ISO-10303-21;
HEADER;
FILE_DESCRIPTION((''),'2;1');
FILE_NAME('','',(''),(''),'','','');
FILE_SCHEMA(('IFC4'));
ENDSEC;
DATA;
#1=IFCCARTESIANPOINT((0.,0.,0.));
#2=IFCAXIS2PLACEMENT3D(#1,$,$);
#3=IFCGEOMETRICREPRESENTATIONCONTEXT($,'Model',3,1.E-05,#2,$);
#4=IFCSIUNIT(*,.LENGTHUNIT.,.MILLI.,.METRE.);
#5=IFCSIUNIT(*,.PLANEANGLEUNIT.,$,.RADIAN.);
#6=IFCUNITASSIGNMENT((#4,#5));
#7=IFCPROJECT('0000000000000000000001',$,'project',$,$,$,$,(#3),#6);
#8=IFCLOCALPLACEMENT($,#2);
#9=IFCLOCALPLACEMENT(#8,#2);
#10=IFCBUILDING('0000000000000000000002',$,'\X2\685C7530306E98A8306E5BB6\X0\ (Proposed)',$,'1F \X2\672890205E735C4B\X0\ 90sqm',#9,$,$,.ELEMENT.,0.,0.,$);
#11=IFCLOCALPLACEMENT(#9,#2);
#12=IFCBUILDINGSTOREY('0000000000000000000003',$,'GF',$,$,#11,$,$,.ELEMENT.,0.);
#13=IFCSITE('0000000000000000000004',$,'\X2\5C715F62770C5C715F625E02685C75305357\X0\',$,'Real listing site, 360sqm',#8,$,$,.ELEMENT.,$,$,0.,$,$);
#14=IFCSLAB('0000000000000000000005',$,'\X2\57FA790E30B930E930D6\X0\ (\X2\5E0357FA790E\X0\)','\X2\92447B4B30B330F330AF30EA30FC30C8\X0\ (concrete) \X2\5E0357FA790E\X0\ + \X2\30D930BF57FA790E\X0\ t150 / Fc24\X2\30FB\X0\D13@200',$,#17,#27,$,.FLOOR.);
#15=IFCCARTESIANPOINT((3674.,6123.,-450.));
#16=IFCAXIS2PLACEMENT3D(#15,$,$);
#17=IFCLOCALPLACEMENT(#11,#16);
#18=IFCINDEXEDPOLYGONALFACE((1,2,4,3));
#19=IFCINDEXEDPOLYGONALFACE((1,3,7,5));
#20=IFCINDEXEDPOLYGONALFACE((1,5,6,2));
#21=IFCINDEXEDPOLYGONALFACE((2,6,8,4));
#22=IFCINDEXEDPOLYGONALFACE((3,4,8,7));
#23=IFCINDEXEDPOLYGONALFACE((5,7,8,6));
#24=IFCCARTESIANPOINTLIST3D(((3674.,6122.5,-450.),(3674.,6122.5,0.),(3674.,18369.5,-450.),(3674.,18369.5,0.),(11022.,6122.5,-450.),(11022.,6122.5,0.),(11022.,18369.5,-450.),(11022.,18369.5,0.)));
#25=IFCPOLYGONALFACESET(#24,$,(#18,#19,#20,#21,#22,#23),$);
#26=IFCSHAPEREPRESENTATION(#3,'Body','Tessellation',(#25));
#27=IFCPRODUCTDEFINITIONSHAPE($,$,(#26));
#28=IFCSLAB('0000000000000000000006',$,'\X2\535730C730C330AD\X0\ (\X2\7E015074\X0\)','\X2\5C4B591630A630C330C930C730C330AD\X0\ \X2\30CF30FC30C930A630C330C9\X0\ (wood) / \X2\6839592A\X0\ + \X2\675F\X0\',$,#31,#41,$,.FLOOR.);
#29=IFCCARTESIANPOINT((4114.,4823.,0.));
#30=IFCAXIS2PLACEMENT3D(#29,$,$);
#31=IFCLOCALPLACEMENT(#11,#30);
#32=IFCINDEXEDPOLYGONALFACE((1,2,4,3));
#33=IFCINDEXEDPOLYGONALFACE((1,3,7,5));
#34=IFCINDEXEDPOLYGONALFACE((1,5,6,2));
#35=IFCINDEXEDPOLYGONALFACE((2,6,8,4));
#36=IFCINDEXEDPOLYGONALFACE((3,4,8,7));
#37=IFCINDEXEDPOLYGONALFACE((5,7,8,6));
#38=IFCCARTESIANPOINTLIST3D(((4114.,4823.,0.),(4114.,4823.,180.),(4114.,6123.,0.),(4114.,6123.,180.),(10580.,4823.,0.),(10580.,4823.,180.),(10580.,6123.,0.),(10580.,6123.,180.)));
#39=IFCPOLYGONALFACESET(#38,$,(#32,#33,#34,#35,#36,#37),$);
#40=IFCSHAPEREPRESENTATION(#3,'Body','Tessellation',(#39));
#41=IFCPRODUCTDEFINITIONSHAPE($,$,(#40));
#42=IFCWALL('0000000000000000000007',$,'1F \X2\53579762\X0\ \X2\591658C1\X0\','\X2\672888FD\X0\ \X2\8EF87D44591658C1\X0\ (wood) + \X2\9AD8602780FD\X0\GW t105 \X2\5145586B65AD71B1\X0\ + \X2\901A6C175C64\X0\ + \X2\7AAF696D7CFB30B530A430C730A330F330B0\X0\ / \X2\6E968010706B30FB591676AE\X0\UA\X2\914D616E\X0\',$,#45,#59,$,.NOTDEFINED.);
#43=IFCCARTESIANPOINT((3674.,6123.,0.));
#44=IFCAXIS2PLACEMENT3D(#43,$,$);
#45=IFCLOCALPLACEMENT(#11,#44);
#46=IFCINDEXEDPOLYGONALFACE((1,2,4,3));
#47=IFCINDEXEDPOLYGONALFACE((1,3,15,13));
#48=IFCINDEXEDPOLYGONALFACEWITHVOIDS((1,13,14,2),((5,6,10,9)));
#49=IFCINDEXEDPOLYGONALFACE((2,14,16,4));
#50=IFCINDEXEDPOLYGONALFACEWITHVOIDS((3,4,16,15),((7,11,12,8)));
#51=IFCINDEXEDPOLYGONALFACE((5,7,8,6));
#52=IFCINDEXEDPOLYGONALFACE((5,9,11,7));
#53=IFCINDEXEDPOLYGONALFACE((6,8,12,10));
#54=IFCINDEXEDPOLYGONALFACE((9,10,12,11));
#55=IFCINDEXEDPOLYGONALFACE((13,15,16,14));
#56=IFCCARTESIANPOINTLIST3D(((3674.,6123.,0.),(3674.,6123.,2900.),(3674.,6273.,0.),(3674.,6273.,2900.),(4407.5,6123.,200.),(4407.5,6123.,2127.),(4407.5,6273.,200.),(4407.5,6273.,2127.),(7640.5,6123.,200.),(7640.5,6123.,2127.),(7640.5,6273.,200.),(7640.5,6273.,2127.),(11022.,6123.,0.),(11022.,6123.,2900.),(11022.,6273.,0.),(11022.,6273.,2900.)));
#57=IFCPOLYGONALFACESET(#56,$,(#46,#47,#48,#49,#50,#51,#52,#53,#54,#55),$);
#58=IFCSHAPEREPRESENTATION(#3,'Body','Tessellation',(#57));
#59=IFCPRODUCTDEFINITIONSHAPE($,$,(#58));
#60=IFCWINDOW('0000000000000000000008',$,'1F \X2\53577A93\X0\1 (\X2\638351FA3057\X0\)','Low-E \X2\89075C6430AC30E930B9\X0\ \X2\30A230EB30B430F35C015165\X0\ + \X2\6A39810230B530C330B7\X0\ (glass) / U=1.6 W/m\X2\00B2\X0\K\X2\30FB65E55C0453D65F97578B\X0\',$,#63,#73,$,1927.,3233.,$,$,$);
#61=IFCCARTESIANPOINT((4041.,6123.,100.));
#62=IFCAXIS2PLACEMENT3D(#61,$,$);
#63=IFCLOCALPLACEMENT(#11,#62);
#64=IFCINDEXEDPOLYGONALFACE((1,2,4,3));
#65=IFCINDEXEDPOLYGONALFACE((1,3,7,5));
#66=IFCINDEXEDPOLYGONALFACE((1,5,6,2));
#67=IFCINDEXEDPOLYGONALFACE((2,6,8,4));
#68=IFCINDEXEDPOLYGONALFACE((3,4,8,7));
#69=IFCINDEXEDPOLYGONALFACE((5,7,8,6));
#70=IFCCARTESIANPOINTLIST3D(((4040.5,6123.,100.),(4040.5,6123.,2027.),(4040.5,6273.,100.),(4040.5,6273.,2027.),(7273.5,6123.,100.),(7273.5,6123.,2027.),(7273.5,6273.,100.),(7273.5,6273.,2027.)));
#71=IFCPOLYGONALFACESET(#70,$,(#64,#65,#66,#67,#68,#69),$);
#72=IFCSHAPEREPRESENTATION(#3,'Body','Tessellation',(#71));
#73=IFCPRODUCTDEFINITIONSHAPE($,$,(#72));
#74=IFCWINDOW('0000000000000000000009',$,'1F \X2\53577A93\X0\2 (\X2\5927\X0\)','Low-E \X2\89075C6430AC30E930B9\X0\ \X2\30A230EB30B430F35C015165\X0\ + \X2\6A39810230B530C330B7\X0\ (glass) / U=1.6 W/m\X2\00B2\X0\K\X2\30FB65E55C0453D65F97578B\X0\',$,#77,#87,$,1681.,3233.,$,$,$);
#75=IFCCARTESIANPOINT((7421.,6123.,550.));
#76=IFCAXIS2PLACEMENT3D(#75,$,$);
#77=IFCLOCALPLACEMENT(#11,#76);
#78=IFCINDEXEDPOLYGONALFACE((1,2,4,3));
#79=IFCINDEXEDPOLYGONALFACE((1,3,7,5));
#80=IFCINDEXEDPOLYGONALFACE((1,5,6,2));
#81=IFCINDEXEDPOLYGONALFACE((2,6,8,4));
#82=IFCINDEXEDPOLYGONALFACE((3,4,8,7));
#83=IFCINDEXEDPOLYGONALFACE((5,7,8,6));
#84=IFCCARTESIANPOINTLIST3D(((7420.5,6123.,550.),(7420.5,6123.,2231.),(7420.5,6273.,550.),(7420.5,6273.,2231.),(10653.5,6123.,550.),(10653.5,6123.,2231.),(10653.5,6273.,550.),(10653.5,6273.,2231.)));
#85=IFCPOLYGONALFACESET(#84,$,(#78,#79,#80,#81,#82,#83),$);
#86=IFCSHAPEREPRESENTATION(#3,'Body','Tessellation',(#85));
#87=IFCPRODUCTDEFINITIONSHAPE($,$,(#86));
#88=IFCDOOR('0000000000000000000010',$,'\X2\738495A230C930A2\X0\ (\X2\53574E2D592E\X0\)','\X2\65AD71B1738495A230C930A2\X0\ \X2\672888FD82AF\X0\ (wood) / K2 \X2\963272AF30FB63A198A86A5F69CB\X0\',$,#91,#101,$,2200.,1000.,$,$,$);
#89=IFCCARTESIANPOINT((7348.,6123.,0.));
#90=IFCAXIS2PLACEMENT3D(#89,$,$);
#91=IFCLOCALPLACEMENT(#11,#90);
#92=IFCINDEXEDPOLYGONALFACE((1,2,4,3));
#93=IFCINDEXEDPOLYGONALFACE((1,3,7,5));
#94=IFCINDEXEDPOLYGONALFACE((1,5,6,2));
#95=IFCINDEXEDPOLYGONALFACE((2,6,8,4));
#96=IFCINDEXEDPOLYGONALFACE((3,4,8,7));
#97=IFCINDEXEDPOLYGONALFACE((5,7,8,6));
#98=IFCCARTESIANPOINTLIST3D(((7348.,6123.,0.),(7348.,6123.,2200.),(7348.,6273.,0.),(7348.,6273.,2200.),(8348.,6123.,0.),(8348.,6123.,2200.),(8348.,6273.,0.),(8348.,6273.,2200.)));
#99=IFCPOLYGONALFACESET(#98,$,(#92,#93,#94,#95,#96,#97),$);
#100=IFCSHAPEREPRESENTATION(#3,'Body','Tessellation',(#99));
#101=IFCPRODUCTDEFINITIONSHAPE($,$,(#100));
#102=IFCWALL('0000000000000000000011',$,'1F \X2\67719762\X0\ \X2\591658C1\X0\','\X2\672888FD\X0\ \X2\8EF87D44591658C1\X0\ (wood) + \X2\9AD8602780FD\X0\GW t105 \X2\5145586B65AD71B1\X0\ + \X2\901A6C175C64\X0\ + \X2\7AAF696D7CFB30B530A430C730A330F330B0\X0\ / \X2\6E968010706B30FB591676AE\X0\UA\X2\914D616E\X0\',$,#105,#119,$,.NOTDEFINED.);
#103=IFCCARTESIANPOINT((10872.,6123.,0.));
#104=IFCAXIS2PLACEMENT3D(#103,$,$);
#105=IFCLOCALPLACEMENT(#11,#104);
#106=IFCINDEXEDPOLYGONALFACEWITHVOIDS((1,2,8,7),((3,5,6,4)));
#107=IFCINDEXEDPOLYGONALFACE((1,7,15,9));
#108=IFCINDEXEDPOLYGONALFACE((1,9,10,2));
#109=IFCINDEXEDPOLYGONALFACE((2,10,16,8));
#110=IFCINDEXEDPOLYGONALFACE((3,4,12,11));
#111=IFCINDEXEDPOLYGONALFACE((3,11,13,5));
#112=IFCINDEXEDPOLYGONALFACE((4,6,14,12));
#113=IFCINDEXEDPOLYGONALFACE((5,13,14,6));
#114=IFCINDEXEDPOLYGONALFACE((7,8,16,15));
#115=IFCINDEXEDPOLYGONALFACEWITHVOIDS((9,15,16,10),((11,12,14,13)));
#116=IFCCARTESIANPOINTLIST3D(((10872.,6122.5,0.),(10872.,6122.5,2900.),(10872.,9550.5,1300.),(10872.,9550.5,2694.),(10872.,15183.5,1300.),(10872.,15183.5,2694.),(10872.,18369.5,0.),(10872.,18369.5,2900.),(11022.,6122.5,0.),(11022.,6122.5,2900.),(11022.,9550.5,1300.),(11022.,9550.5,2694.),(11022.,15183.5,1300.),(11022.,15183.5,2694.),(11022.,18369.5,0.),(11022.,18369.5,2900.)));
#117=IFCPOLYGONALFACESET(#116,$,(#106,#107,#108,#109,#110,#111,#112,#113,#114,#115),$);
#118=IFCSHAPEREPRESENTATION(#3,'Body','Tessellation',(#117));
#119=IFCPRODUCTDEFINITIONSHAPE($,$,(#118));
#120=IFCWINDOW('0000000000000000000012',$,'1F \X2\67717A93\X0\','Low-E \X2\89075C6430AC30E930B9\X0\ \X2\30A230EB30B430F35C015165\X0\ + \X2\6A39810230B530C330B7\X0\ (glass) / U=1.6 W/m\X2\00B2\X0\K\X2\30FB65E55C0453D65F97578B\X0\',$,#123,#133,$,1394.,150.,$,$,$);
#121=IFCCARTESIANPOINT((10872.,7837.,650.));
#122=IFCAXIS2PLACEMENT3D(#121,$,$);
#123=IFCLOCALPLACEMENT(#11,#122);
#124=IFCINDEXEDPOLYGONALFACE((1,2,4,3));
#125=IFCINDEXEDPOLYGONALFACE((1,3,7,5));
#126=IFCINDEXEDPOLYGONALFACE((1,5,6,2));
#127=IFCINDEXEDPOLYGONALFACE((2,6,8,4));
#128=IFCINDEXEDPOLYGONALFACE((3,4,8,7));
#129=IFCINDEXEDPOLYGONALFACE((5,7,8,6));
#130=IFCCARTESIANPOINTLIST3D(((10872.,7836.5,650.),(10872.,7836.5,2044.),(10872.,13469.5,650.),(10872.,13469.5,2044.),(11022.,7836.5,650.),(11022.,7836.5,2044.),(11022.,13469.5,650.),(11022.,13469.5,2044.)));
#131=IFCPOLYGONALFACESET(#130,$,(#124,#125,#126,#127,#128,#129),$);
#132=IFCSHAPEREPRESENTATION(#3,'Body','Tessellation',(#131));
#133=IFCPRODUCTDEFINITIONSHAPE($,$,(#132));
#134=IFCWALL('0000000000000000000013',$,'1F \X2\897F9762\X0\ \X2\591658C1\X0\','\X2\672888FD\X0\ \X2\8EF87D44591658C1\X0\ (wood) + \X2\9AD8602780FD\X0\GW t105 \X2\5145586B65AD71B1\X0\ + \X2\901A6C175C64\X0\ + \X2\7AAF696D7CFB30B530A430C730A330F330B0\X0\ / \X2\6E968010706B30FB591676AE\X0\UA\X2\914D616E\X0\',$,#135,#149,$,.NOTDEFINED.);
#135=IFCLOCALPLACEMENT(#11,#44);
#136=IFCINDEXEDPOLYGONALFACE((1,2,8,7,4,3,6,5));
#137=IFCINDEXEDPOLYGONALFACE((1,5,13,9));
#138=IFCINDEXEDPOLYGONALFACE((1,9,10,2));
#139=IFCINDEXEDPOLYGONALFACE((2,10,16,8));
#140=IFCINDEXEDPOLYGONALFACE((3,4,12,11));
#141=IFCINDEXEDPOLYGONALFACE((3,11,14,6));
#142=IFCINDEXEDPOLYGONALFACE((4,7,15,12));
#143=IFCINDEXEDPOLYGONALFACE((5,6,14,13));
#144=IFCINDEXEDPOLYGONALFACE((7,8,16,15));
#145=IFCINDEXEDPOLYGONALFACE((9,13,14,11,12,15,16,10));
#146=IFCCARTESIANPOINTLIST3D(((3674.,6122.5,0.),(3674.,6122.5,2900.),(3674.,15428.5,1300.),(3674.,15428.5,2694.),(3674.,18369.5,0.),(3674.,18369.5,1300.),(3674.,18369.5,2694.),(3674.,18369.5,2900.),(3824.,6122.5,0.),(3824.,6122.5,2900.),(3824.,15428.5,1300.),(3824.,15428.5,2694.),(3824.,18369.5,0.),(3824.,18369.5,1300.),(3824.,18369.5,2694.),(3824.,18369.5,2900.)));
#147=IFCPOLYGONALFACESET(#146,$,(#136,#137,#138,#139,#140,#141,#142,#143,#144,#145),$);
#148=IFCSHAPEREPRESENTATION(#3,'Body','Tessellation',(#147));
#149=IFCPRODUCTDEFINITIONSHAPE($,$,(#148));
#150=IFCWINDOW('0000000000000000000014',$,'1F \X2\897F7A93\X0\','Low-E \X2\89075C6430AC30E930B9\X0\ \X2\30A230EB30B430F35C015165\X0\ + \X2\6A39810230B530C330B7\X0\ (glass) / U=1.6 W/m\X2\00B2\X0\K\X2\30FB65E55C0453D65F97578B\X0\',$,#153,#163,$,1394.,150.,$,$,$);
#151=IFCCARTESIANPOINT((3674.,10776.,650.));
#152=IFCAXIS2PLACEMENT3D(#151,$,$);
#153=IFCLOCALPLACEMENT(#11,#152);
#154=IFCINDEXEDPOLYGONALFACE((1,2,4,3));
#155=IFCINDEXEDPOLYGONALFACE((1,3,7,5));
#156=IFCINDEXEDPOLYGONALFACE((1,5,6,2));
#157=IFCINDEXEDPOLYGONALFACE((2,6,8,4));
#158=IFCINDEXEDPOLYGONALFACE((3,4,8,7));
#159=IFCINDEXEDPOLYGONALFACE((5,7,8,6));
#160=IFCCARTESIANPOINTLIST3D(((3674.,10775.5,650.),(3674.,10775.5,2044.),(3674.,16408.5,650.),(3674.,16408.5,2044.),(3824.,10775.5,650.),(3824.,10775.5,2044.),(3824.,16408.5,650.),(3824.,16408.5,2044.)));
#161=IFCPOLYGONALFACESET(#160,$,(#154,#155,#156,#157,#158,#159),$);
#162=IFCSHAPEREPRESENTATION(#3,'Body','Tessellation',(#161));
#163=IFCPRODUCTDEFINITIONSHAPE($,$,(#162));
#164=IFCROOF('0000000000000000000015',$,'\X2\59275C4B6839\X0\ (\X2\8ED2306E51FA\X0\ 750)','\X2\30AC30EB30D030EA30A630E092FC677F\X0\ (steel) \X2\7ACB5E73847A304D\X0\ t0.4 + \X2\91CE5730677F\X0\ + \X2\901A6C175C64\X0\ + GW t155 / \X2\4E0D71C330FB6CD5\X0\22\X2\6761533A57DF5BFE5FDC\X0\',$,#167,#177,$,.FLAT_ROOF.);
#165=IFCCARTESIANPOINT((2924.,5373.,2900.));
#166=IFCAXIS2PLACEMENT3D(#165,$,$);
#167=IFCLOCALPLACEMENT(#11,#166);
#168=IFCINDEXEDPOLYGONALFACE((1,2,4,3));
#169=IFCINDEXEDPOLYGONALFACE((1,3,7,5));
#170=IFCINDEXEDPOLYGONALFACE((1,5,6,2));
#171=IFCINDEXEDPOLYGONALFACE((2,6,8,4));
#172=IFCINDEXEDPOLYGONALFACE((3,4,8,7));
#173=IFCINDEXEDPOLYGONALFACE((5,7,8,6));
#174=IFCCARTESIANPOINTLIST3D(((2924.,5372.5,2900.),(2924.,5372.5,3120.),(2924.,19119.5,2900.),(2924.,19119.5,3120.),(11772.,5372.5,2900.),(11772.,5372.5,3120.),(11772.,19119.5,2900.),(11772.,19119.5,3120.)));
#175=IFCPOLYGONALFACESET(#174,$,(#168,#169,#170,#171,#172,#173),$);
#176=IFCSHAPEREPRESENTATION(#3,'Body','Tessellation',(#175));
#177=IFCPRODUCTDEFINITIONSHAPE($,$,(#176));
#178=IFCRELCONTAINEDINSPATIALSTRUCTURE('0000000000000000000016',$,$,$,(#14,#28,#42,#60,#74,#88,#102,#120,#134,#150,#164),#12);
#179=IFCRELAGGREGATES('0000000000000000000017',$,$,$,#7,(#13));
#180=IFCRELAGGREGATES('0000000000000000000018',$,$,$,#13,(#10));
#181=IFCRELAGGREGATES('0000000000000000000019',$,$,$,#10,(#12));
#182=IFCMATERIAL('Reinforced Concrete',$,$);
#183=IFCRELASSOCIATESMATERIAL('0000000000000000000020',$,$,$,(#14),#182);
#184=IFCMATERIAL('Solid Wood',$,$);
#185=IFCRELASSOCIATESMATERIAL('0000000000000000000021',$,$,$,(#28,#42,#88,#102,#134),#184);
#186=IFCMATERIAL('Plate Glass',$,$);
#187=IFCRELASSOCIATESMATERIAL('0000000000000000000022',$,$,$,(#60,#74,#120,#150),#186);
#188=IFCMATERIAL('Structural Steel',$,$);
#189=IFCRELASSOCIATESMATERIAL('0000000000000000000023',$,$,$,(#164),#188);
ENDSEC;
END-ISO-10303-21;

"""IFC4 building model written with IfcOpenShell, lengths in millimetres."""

from ifc_helpers import new_model, si_unit, frame, frame_2d, origin, place, context, project, spatial, rectangle, extrude, material, element, fill, save


model = new_model("IFC4")

# Units and contexts
model_context = context("Model", 3, precision=1e-05, world=origin())
ifc_project = project(units=[si_unit("LENGTHUNIT", "METRE", prefix="MILLI"), si_unit("PLANEANGLEUNIT", "RADIAN")], contexts=[model_context])

# Site, building, storey
site_placement = place(None, origin())
site = spatial("IfcSite", under=ifc_project, at=site_placement, Name="山形県山形市桜田南", ObjectType="Real listing site, 360sqm", CompositionType="ELEMENT", RefElevation=0.0)
building_placement = place(site_placement, origin())
building = spatial("IfcBuilding", under=site, at=building_placement, Name="桜田の風の家 (Proposed)", ObjectType="1F 木造平屋 90sqm", CompositionType="ELEMENT", ElevationOfRefHeight=0.0, ElevationOfTerrain=0.0)
storey_placement = place(building_placement, origin())
storey = spatial("IfcBuildingStorey", under=building, at=storey_placement, Name="GF", CompositionType="ELEMENT", Elevation=0.0)

# Slabs
ifc_material_1 = material(Name="Reinforced Concrete")
slab_1_placement = place(storey_placement, frame((3674.0, 6123.0, -450.0)))
element("IfcSlab", 1, at=slab_1_placement, inside=storey, material=ifc_material_1, Name="基礎スラブ (布基礎)", Description="鉄筋コンクリート (concrete) 布基礎 + ベタ基礎 t150 / Fc24・D13@200", PredefinedType="FLOOR", context=model_context, shape_type="SweptSolid", body=[
    extrude(rectangle(XDim=7348.0, YDim=12247.0, at=frame_2d((3674.0, 6123.0))), frame((3674.0, 6123.0, -450.0)), (0.0, 0.0, 1.0), 450.0),
])
ifc_material_2 = material(Name="Solid Wood")
slab_2_placement = place(storey_placement, frame((4114.0, 4823.0, 0.0)))
element("IfcSlab", 2, at=slab_2_placement, inside=storey, material=ifc_material_2, Name="南デッキ (縁側)", Description="屋外ウッドデッキ ハードウッド (wood) / 根太 + 束", PredefinedType="FLOOR", context=model_context, shape_type="SweptSolid", body=[
    extrude(rectangle(XDim=6466.0, YDim=1300.0, at=frame_2d((3233.0, 650.0))), frame((4114.0, 4823.0, 0.0)), (0.0, 0.0, 1.0), 180.0),
])

# Wall, openings, windows, door
wall_1_placement = place(storey_placement, frame((3674.0, 6123.0, 0.0)))
wall_1 = element("IfcWall", 3, at=wall_1_placement, inside=storey, material=ifc_material_2, Name="1F 南面 外壁", Description="木製 軸組外壁 (wood) + 高性能GW t105 充填断熱 + 通気層 + 窯業系サイディング / 準耐火・外皮UA配慮", PredefinedType="NOTDEFINED", context=model_context, shape_type="SweptSolid", body=[
    extrude(rectangle(XDim=7348.0, YDim=150.0, at=frame_2d((3674.0, 75.0))), frame((3674.0, 6123.0, 0.0)), (0.0, 0.0, 1.0), 2900.0),
])
opening_1_placement = place(storey_placement, frame((4041.0, 6123.0, 100.0)))
opening_1 = element("IfcOpeningElement", 4, at=opening_1_placement, cuts=wall_1, PredefinedType="NOTDEFINED", context=model_context, shape_type="SweptSolid", body=[
    extrude(rectangle(XDim=3233.0, YDim=150.0, at=frame_2d((1616.0, 75.0))), frame((4041.0, 6123.0, 100.0)), (0.0, 0.0, 1.0), 1927.0),
])
opening_2_placement = place(storey_placement, frame((7421.0, 6123.0, 550.0)))
opening_2 = element("IfcOpeningElement", 5, at=opening_2_placement, cuts=wall_1, PredefinedType="NOTDEFINED", context=model_context, shape_type="SweptSolid", body=[
    extrude(rectangle(XDim=3233.0, YDim=150.0, at=frame_2d((1616.0, 75.0))), frame((7421.0, 6123.0, 550.0)), (0.0, 0.0, 1.0), 1681.0),
])
opening_3_placement = place(storey_placement, frame((7348.0, 6123.0, 0.0)))
opening_3 = element("IfcOpeningElement", 6, at=opening_3_placement, cuts=wall_1, PredefinedType="NOTDEFINED", context=model_context, shape_type="SweptSolid", body=[
    extrude(rectangle(XDim=1000.0, YDim=150.0, at=frame_2d((500.0, 75.0))), frame((7348.0, 6123.0, 0.0)), (0.0, 0.0, 1.0), 2200.0),
])
ifc_material_3 = material(Name="Plate Glass")
window_1_placement = place(storey_placement, frame((4041.0, 6123.0, 100.0)))
window_1 = element("IfcWindow", 7, at=window_1_placement, inside=storey, material=ifc_material_3, Name="1F 南窓1 (掃出し)", Description="Low-E 複層ガラス アルゴン封入 + 樹脂サッシ (glass) / U=1.6 W/m²K・日射取得型", OverallHeight=1927.0, OverallWidth=3233.0, context=model_context, shape_type="SweptSolid", body=[
    extrude(rectangle(XDim=3233.0, YDim=150.0, at=frame_2d((1616.0, 75.0))), frame((4041.0, 6123.0, 100.0)), (0.0, 0.0, 1.0), 1927.0),
])
fill(opening_1, window_1)
window_2_placement = place(storey_placement, frame((7421.0, 6123.0, 550.0)))
window_2 = element("IfcWindow", 8, at=window_2_placement, inside=storey, material=ifc_material_3, Name="1F 南窓2 (大)", Description="Low-E 複層ガラス アルゴン封入 + 樹脂サッシ (glass) / U=1.6 W/m²K・日射取得型", OverallHeight=1681.0, OverallWidth=3233.0, context=model_context, shape_type="SweptSolid", body=[
    extrude(rectangle(XDim=3233.0, YDim=150.0, at=frame_2d((1616.0, 75.0))), frame((7421.0, 6123.0, 550.0)), (0.0, 0.0, 1.0), 1681.0),
])
fill(opening_2, window_2)
door_placement = place(storey_placement, frame((7348.0, 6123.0, 0.0)))
door = element("IfcDoor", 9, at=door_placement, inside=storey, material=ifc_material_2, Name="玄関ドア (南中央)", Description="断熱玄関ドア 木製芯 (wood) / K2 防犯・採風機構", OverallHeight=2200.0, OverallWidth=1000.0, context=model_context, shape_type="SweptSolid", body=[
    extrude(rectangle(XDim=1000.0, YDim=150.0, at=frame_2d((500.0, 75.0))), frame((7348.0, 6123.0, 0.0)), (0.0, 0.0, 1.0), 2200.0),
])
fill(opening_3, door)

# Walls, openings, windows
wall_2_placement = place(storey_placement, frame((10872.0, 6123.0, 0.0)))
wall_2 = element("IfcWall", 10, at=wall_2_placement, inside=storey, material=ifc_material_2, Name="1F 東面 外壁", Description="木製 軸組外壁 (wood) + 高性能GW t105 充填断熱 + 通気層 + 窯業系サイディング / 準耐火・外皮UA配慮", PredefinedType="NOTDEFINED", context=model_context, shape_type="SweptSolid", body=[
    extrude(rectangle(XDim=150.0, YDim=12247.0, at=frame_2d((75.0, 6123.0))), frame((10872.0, 6123.0, 0.0)), (0.0, 0.0, 1.0), 2900.0),
])
opening_4_placement = place(storey_placement, frame((10872.0, 7837.0, 650.0)))
opening_4 = element("IfcOpeningElement", 11, at=opening_4_placement, cuts=wall_2, PredefinedType="NOTDEFINED", context=model_context, shape_type="SweptSolid", body=[
    extrude(rectangle(XDim=150.0, YDim=5633.0, at=frame_2d((75.0, 2816.0))), frame((10872.0, 7837.0, 650.0)), (0.0, 0.0, 1.0), 1394.0),
])
window_3_placement = place(storey_placement, frame((10872.0, 7837.0, 650.0)))
window_3 = element("IfcWindow", 12, at=window_3_placement, inside=storey, material=ifc_material_3, Name="1F 東窓", Description="Low-E 複層ガラス アルゴン封入 + 樹脂サッシ (glass) / U=1.6 W/m²K・日射取得型", OverallHeight=1394.0, OverallWidth=150.0, context=model_context, shape_type="SweptSolid", body=[
    extrude(rectangle(XDim=150.0, YDim=5633.0, at=frame_2d((75.0, 2816.0))), frame((10872.0, 7837.0, 650.0)), (0.0, 0.0, 1.0), 1394.0),
])
fill(opening_4, window_3)
wall_3_placement = place(storey_placement, frame((3674.0, 6123.0, 0.0)))
wall_3 = element("IfcWall", 13, at=wall_3_placement, inside=storey, material=ifc_material_2, Name="1F 西面 外壁", Description="木製 軸組外壁 (wood) + 高性能GW t105 充填断熱 + 通気層 + 窯業系サイディング / 準耐火・外皮UA配慮", PredefinedType="NOTDEFINED", context=model_context, shape_type="SweptSolid", body=[
    extrude(rectangle(XDim=150.0, YDim=12247.0, at=frame_2d((75.0, 6123.0))), frame((3674.0, 6123.0, 0.0)), (0.0, 0.0, 1.0), 2900.0),
])
opening_5_placement = place(storey_placement, frame((3674.0, 10776.0, 650.0)))
opening_5 = element("IfcOpeningElement", 14, at=opening_5_placement, cuts=wall_3, PredefinedType="NOTDEFINED", context=model_context, shape_type="SweptSolid", body=[
    extrude(rectangle(XDim=150.0, YDim=5633.0, at=frame_2d((75.0, 2816.0))), frame((3674.0, 10776.0, 650.0)), (0.0, 0.0, 1.0), 1394.0),
])
window_4_placement = place(storey_placement, frame((3674.0, 10776.0, 650.0)))
window_4 = element("IfcWindow", 15, at=window_4_placement, inside=storey, material=ifc_material_3, Name="1F 西窓", Description="Low-E 複層ガラス アルゴン封入 + 樹脂サッシ (glass) / U=1.6 W/m²K・日射取得型", OverallHeight=1394.0, OverallWidth=150.0, context=model_context, shape_type="SweptSolid", body=[
    extrude(rectangle(XDim=150.0, YDim=5633.0, at=frame_2d((75.0, 2816.0))), frame((3674.0, 10776.0, 650.0)), (0.0, 0.0, 1.0), 1394.0),
])
fill(opening_5, window_4)

# Roof
ifc_material_4 = material(Name="Structural Steel")
roof_placement = place(storey_placement, frame((2924.0, 5373.0, 2900.0)))
element("IfcRoof", 16, at=roof_placement, inside=storey, material=ifc_material_4, Name="大屋根 (軒の出 750)", Description="ガルバリウム鋼板 (steel) 立平葺き t0.4 + 野地板 + 通気層 + GW t155 / 不燃・法22条区域対応", PredefinedType="FLAT_ROOF", context=model_context, shape_type="SweptSolid", body=[
    extrude(rectangle(XDim=8848.0, YDim=13747.0, at=frame_2d((4424.0, 6873.0))), frame((2924.0, 5373.0, 2900.0)), (0.0, 0.0, 1.0), 220.0),
])

save(model, "model.ifc")
